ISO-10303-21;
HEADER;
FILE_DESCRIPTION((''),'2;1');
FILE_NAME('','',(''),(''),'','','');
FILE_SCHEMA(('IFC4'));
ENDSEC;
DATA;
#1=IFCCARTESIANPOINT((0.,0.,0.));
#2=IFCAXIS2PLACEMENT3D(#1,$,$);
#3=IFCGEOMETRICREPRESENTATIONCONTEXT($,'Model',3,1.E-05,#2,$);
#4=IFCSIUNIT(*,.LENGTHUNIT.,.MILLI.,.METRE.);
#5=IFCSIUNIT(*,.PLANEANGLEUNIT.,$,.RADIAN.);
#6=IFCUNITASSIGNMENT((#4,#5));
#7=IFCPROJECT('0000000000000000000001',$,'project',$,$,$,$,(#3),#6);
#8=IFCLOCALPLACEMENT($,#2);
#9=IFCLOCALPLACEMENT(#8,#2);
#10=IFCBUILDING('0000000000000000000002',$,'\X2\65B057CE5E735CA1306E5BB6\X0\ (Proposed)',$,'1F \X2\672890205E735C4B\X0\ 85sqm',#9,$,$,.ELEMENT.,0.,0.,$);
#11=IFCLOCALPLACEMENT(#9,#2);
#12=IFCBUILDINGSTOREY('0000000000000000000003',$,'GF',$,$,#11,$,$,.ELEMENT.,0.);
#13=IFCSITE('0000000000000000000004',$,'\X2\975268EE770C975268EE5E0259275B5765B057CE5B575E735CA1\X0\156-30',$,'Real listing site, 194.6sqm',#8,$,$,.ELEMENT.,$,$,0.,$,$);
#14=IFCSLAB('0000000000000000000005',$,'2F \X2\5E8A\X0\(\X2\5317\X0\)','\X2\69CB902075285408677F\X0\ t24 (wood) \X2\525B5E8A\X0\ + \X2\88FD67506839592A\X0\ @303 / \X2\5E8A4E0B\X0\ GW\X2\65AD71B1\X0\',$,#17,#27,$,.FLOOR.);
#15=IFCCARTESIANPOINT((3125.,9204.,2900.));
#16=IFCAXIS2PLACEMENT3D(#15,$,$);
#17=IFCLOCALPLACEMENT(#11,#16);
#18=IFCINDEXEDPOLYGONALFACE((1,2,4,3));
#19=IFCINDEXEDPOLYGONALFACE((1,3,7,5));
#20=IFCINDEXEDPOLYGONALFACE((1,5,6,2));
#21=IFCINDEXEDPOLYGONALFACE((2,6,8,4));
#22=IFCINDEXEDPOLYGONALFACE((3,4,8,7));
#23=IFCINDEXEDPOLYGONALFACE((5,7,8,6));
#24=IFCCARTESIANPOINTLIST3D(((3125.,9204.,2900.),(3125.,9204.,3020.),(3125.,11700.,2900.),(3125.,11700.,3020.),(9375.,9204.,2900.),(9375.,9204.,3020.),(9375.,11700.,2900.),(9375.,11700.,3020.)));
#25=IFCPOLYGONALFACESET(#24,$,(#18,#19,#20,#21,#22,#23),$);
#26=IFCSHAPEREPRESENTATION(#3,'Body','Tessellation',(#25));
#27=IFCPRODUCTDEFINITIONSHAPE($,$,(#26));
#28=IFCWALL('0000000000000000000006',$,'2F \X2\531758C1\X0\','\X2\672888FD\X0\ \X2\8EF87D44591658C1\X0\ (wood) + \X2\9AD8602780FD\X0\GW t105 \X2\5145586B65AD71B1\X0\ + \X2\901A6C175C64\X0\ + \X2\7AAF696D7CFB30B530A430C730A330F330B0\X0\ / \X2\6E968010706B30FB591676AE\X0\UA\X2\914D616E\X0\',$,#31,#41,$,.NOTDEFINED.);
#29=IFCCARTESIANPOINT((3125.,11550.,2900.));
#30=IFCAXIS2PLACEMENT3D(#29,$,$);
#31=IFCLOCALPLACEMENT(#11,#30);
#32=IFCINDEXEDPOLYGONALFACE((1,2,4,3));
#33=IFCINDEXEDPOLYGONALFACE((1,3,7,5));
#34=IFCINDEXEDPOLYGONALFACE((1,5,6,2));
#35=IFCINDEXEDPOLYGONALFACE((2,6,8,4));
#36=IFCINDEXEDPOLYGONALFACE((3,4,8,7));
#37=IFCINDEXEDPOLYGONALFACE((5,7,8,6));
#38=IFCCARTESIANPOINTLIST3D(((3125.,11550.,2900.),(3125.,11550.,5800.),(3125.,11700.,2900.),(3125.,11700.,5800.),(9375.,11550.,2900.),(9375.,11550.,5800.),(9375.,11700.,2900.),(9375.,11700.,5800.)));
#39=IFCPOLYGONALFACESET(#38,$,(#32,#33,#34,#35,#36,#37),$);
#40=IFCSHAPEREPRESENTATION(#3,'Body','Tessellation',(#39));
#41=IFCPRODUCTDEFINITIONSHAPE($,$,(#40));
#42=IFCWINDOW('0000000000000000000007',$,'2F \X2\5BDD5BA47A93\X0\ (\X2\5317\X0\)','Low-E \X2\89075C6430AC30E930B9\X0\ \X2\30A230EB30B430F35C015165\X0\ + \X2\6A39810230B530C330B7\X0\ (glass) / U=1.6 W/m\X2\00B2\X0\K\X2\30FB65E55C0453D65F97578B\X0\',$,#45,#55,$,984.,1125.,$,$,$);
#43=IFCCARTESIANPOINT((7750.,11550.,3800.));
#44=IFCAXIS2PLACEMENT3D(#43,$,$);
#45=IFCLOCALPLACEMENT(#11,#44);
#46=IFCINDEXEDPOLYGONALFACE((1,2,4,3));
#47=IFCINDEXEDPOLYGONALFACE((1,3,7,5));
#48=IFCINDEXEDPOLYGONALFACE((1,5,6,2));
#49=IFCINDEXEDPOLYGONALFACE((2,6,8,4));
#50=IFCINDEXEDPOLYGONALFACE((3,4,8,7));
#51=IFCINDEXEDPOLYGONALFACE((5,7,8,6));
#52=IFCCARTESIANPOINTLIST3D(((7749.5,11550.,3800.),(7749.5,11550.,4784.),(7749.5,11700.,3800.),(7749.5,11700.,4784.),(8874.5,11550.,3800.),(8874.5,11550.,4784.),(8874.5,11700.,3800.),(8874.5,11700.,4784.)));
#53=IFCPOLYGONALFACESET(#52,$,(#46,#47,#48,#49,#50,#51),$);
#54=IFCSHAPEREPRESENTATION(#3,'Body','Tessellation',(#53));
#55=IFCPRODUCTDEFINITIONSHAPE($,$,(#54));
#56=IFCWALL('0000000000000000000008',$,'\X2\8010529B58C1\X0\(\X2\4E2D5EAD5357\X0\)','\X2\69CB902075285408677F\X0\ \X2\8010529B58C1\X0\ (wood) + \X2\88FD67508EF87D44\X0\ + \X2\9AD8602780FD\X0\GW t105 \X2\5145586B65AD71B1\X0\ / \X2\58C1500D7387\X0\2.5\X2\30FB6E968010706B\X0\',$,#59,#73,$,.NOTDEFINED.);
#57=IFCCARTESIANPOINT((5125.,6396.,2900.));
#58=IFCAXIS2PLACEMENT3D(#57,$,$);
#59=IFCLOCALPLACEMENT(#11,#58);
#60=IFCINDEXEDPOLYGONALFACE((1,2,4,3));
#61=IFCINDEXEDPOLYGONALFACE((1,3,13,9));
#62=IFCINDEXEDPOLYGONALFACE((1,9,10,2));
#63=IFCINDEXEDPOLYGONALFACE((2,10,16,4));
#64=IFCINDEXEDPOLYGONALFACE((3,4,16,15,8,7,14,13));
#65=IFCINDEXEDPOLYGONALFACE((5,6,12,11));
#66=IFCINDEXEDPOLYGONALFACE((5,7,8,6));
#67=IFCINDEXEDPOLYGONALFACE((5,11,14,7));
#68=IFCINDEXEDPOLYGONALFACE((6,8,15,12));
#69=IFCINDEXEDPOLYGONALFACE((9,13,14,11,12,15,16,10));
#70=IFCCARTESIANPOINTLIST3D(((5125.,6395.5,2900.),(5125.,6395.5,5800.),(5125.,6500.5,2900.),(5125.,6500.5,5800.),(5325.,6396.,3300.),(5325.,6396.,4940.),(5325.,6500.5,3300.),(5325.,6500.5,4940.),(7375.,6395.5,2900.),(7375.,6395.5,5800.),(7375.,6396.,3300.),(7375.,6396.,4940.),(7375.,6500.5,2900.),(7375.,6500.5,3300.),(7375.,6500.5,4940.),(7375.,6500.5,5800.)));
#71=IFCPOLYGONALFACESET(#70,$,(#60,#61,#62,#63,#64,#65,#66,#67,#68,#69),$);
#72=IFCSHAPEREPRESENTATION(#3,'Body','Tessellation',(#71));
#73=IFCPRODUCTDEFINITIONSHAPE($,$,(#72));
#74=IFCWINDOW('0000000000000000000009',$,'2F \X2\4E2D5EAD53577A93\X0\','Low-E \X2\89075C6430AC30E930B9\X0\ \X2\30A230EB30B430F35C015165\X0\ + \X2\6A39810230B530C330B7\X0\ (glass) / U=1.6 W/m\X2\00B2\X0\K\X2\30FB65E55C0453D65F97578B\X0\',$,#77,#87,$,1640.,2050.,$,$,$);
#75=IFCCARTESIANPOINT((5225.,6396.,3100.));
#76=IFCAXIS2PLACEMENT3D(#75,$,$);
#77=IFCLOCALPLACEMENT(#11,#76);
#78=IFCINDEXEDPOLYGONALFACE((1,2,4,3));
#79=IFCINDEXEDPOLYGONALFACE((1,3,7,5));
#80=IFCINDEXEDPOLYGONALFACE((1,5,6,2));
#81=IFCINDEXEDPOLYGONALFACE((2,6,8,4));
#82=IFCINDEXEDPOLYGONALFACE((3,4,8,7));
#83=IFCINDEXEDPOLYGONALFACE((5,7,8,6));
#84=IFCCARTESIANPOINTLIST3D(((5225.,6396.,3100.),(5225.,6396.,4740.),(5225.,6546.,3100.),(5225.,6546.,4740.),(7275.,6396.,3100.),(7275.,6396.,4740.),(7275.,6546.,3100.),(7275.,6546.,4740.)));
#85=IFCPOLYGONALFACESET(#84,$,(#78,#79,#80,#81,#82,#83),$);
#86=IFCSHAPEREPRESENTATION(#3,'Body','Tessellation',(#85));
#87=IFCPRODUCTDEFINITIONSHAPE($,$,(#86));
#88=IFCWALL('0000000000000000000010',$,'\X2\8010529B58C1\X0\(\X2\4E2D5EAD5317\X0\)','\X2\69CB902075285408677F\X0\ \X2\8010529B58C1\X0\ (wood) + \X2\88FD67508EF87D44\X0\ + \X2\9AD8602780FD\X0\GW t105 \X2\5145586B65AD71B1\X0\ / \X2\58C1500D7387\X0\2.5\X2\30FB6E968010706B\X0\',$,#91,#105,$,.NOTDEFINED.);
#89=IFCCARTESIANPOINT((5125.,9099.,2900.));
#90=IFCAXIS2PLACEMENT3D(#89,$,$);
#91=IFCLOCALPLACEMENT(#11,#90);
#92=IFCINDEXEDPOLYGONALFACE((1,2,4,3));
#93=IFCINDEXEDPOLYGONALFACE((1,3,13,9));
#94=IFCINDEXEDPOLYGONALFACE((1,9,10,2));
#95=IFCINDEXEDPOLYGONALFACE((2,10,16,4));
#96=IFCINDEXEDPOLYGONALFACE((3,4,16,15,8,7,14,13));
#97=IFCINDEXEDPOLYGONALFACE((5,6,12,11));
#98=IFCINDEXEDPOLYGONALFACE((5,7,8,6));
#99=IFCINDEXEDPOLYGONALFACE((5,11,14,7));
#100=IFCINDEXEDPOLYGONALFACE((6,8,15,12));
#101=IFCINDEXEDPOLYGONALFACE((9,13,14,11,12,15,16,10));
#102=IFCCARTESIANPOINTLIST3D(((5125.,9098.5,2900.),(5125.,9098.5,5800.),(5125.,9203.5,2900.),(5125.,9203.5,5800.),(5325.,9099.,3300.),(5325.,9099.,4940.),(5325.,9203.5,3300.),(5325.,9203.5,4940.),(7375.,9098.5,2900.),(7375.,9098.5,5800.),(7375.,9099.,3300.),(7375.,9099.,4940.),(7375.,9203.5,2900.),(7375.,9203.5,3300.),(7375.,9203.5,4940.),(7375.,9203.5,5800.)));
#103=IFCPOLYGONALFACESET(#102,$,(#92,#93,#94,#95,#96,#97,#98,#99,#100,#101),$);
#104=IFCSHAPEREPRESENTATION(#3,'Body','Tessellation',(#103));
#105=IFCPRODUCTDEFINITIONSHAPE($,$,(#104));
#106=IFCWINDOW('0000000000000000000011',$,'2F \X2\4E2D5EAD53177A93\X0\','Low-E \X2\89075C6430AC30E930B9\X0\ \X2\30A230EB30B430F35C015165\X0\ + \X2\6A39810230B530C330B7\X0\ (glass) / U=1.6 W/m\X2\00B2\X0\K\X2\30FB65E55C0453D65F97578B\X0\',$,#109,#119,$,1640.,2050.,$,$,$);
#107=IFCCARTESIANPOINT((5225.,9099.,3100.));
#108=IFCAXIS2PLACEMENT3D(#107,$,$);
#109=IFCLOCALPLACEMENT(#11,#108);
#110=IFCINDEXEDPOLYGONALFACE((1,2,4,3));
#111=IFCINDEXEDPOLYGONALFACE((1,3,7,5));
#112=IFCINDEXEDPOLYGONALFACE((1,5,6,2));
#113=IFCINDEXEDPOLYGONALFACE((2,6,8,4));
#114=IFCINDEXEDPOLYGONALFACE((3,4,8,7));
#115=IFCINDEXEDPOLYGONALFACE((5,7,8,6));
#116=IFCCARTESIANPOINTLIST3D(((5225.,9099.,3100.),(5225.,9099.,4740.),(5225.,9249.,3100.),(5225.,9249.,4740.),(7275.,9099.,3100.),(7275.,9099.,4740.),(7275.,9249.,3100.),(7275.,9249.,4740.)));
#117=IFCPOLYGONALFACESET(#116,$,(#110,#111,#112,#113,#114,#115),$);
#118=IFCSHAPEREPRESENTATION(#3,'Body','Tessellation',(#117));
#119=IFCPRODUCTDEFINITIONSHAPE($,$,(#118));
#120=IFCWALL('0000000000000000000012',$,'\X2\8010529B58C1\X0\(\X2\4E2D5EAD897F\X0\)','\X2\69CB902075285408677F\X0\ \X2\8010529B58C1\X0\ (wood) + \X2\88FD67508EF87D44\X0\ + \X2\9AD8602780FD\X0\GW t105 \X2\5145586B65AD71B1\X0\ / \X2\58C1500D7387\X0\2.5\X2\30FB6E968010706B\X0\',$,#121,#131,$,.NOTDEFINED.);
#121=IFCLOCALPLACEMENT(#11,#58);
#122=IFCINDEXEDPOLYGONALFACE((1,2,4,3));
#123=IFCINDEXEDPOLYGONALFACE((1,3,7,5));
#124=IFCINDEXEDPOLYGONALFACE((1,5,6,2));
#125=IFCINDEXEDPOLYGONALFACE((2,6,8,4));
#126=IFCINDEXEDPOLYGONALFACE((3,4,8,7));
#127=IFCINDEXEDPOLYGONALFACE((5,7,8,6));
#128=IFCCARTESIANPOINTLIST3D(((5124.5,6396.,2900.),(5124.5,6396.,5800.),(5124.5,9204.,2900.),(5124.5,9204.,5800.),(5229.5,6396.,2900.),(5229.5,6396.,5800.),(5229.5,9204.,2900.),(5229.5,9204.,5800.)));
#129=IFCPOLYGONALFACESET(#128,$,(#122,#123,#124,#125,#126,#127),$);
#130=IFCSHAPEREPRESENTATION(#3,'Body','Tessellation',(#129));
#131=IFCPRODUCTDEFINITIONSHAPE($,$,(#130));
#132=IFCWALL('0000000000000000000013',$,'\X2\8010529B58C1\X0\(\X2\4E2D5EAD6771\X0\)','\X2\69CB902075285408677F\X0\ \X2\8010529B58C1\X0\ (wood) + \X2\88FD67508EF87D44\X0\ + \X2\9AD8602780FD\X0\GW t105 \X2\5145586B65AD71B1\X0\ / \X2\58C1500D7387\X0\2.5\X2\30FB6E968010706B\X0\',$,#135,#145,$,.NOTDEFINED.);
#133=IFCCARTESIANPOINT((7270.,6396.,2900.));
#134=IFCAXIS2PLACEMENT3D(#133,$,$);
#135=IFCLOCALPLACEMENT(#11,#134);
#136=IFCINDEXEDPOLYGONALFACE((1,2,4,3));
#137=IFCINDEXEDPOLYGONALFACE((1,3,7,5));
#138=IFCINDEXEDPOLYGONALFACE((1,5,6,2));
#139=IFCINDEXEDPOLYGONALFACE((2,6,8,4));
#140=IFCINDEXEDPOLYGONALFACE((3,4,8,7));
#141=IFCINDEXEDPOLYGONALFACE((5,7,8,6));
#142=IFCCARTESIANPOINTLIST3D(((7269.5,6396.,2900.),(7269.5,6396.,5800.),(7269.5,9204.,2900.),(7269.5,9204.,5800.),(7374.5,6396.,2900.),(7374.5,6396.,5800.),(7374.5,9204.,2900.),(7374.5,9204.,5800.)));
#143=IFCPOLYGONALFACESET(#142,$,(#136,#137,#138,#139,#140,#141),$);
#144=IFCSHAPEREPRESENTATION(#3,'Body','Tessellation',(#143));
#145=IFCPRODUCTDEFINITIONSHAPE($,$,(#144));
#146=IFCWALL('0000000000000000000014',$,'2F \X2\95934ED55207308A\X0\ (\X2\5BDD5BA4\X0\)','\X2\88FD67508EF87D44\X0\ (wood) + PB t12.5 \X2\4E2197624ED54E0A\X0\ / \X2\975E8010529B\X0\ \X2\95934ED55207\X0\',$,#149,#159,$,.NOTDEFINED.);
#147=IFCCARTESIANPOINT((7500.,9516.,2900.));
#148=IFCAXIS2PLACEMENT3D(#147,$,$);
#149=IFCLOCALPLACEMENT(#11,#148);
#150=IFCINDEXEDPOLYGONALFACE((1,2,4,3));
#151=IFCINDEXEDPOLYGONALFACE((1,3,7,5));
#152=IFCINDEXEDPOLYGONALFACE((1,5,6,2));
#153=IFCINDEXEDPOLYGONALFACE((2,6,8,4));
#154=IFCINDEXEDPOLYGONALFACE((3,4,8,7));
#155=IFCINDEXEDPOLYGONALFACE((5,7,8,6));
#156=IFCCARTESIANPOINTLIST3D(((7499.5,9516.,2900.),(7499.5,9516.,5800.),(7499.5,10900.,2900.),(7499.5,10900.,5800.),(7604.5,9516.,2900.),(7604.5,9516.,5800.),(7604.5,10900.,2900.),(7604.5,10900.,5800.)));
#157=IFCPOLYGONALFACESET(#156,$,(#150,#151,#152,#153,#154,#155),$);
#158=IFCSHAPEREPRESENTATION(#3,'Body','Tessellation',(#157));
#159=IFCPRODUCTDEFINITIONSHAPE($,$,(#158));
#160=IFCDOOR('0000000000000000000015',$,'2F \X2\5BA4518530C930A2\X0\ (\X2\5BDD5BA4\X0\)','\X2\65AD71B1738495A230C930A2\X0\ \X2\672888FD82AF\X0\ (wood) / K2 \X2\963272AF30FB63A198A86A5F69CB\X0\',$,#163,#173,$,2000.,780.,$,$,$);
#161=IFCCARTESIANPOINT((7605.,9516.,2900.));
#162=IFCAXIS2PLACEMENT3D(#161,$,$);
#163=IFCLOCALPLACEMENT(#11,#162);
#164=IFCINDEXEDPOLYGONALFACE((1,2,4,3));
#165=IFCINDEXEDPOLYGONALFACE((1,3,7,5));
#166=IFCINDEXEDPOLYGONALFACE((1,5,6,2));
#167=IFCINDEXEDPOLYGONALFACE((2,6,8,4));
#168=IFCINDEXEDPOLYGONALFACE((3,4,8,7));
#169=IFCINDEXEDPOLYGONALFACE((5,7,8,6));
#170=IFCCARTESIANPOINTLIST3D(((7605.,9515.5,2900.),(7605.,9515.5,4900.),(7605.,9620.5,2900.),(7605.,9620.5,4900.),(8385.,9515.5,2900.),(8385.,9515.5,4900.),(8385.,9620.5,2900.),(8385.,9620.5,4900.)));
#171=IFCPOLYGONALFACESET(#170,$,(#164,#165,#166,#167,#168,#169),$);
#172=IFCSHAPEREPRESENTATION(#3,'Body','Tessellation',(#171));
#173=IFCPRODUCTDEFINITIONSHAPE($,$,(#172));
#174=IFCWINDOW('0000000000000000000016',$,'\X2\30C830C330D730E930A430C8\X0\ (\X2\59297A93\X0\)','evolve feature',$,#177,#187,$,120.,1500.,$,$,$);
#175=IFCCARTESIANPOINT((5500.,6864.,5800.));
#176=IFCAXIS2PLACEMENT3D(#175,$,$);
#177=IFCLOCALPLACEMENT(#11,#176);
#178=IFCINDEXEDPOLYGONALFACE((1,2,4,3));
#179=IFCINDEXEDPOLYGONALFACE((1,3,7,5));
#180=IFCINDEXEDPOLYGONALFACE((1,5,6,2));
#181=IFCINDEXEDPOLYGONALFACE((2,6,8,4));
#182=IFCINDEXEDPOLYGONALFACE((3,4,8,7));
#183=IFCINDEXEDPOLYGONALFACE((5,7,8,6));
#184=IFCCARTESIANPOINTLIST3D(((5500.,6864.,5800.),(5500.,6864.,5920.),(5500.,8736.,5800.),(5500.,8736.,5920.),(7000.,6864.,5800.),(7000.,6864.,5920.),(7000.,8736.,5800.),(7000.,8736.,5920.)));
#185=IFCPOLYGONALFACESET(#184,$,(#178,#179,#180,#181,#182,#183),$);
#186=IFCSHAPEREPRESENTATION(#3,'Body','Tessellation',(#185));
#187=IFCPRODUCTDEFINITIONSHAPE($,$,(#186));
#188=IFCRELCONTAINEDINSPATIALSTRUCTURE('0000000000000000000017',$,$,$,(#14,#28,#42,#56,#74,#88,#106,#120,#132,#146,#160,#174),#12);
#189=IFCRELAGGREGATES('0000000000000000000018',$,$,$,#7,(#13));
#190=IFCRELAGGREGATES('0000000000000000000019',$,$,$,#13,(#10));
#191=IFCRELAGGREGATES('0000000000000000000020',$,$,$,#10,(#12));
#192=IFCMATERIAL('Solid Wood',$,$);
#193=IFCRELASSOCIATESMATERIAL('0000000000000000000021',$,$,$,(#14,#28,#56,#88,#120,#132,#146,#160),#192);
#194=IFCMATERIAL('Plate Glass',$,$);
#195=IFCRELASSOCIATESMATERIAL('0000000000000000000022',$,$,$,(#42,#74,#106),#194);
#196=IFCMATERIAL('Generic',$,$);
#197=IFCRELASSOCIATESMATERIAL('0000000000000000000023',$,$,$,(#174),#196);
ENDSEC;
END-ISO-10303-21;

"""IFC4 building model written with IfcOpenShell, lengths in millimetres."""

from ifc_helpers import new_model, si_unit, frame, frame_2d, origin, place, context, project, spatial, rectangle, extrude, material, element, fill, save


model = new_model("IFC4")

# Units and contexts
model_context = context("Model", 3, precision=1e-05, world=origin())
ifc_project = project(units=[si_unit("LENGTHUNIT", "METRE", prefix="MILLI"), si_unit("PLANEANGLEUNIT", "RADIAN")], contexts=[model_context])

# Site, building, storey
site_placement = place(None, origin())
site = spatial("IfcSite", under=ifc_project, at=site_placement, Name="青森県青森市大字新城字平岡156-30", ObjectType="Real listing site, 194.6sqm", CompositionType="ELEMENT", RefElevation=0.0)
building_placement = place(site_placement, origin())
building = spatial("IfcBuilding", under=site, at=building_placement, Name="新城平岡の家 (Proposed)", ObjectType="1F 木造平屋 85sqm", CompositionType="ELEMENT", ElevationOfRefHeight=0.0, ElevationOfTerrain=0.0)
storey_placement = place(building_placement, origin())
storey = spatial("IfcBuildingStorey", under=building, at=storey_placement, Name="GF", CompositionType="ELEMENT", Elevation=0.0)

# Slab
ifc_material_1 = material(Name="Solid Wood")
slab_placement = place(storey_placement, frame((3125.0, 9204.0, 2900.0)))
element("IfcSlab", 1, at=slab_placement, inside=storey, material=ifc_material_1, Name="2F 床(北)", Description="構造用合板 t24 (wood) 剛床 + 製材根太 @303 / 床下 GW断熱", PredefinedType="FLOOR", context=model_context, shape_type="SweptSolid", body=[
    extrude(rectangle(XDim=6250.0, YDim=2496.0, at=frame_2d((3125.0, 1248.0))), frame((3125.0, 9204.0, 2900.0)), (0.0, 0.0, 1.0), 120.0),
])

# Walls, openings, windows
wall_1_placement = place(storey_placement, frame((3125.0, 11550.0, 2900.0)))
wall_1 = element("IfcWall", 2, at=wall_1_placement, inside=storey, material=ifc_material_1, Name="2F 北壁", Description="木製 軸組外壁 (wood) + 高性能GW t105 充填断熱 + 通気層 + 窯業系サイディング / 準耐火・外皮UA配慮", PredefinedType="NOTDEFINED", context=model_context, shape_type="SweptSolid", body=[
    extrude(rectangle(XDim=6250.0, YDim=150.0, at=frame_2d((3125.0, 75.0))), frame((3125.0, 11550.0, 2900.0)), (0.0, 0.0, 1.0), 2900.0),
])
opening_1_placement = place(storey_placement, frame((7750.0, 11550.0, 3800.0)))
opening_1 = element("IfcOpeningElement", 3, at=opening_1_placement, cuts=wall_1, PredefinedType="NOTDEFINED", context=model_context, shape_type="SweptSolid", body=[
    extrude(rectangle(XDim=1125.0, YDim=150.0, at=frame_2d((562.0, 75.0))), frame((7750.0, 11550.0, 3800.0)), (0.0, 0.0, 1.0), 984.0),
])
ifc_material_2 = material(Name="Plate Glass")
window_1_placement = place(storey_placement, frame((7750.0, 11550.0, 3800.0)))
window_1 = element("IfcWindow", 4, at=window_1_placement, inside=storey, material=ifc_material_2, Name="2F 寝室窓 (北)", Description="Low-E 複層ガラス アルゴン封入 + 樹脂サッシ (glass) / U=1.6 W/m²K・日射取得型", OverallHeight=984.0, OverallWidth=1125.0, context=model_context, shape_type="SweptSolid", body=[
    extrude(rectangle(XDim=1125.0, YDim=150.0, at=frame_2d((562.0, 75.0))), frame((7750.0, 11550.0, 3800.0)), (0.0, 0.0, 1.0), 984.0),
])
fill(opening_1, window_1)
wall_2_placement = place(storey_placement, frame((5125.0, 6396.0, 2900.0)))
wall_2 = element("IfcWall", 5, at=wall_2_placement, inside=storey, material=ifc_material_1, Name="耐力壁(中庭南)", Description="構造用合板 耐力壁 (wood) + 製材軸組 + 高性能GW t105 充填断熱 / 壁倍率2.5・準耐火", PredefinedType="NOTDEFINED", context=model_context, shape_type="SweptSolid", body=[
    extrude(rectangle(XDim=2250.0, YDim=105.0, at=frame_2d((1125.0, 52.0))), frame((5125.0, 6396.0, 2900.0)), (0.0, 0.0, 1.0), 2900.0),
])
opening_2_placement = place(storey_placement, frame((5225.0, 6396.0, 3100.0)))
opening_2 = element("IfcOpeningElement", 6, at=opening_2_placement, cuts=wall_2, PredefinedType="NOTDEFINED", context=model_context, shape_type="SweptSolid", body=[
    extrude(rectangle(XDim=2050.0, YDim=150.0, at=frame_2d((1025.0, 75.0))), frame((5225.0, 6396.0, 3100.0)), (0.0, 0.0, 1.0), 1640.0),
])
window_2_placement = place(storey_placement, frame((5225.0, 6396.0, 3100.0)))
window_2 = element("IfcWindow", 7, at=window_2_placement, inside=storey, material=ifc_material_2, Name="2F 中庭南窓", Description="Low-E 複層ガラス アルゴン封入 + 樹脂サッシ (glass) / U=1.6 W/m²K・日射取得型", OverallHeight=1640.0, OverallWidth=2050.0, context=model_context, shape_type="SweptSolid", body=[
    extrude(rectangle(XDim=2050.0, YDim=150.0, at=frame_2d((1025.0, 75.0))), frame((5225.0, 6396.0, 3100.0)), (0.0, 0.0, 1.0), 1640.0),
])
fill(opening_2, window_2)
wall_3_placement = place(storey_placement, frame((5125.0, 9099.0, 2900.0)))
wall_3 = element("IfcWall", 8, at=wall_3_placement, inside=storey, material=ifc_material_1, Name="耐力壁(中庭北)", Description="構造用合板 耐力壁 (wood) + 製材軸組 + 高性能GW t105 充填断熱 / 壁倍率2.5・準耐火", PredefinedType="NOTDEFINED", context=model_context, shape_type="SweptSolid", body=[
    extrude(rectangle(XDim=2250.0, YDim=105.0, at=frame_2d((1125.0, 52.0))), frame((5125.0, 9099.0, 2900.0)), (0.0, 0.0, 1.0), 2900.0),
])
opening_3_placement = place(storey_placement, frame((5225.0, 9099.0, 3100.0)))
opening_3 = element("IfcOpeningElement", 9, at=opening_3_placement, cuts=wall_3, PredefinedType="NOTDEFINED", context=model_context, shape_type="SweptSolid", body=[
    extrude(rectangle(XDim=2050.0, YDim=150.0, at=frame_2d((1025.0, 75.0))), frame((5225.0, 9099.0, 3100.0)), (0.0, 0.0, 1.0), 1640.0),
])
window_3_placement = place(storey_placement, frame((5225.0, 9099.0, 3100.0)))
window_3 = element("IfcWindow", 10, at=window_3_placement, inside=storey, material=ifc_material_2, Name="2F 中庭北窓", Description="Low-E 複層ガラス アルゴン封入 + 樹脂サッシ (glass) / U=1.6 W/m²K・日射取得型", OverallHeight=1640.0, OverallWidth=2050.0, context=model_context, shape_type="SweptSolid", body=[
    extrude(rectangle(XDim=2050.0, YDim=150.0, at=frame_2d((1025.0, 75.0))), frame((5225.0, 9099.0, 3100.0)), (0.0, 0.0, 1.0), 1640.0),
])
fill(opening_3, window_3)

# Walls
wall_4_placement = place(storey_placement, frame((5125.0, 6396.0, 2900.0)))
element("IfcWall", 11, at=wall_4_placement, inside=storey, material=ifc_material_1, Name="耐力壁(中庭西)", Description="構造用合板 耐力壁 (wood) + 製材軸組 + 高性能GW t105 充填断熱 / 壁倍率2.5・準耐火", PredefinedType="NOTDEFINED", context=model_context, shape_type="SweptSolid", body=[
    extrude(rectangle(XDim=105.0, YDim=2808.0, at=frame_2d((52.0, 1404.0))), frame((5125.0, 6396.0, 2900.0)), (0.0, 0.0, 1.0), 2900.0),
])
wall_5_placement = place(storey_placement, frame((7270.0, 6396.0, 2900.0)))
element("IfcWall", 12, at=wall_5_placement, inside=storey, material=ifc_material_1, Name="耐力壁(中庭東)", Description="構造用合板 耐力壁 (wood) + 製材軸組 + 高性能GW t105 充填断熱 / 壁倍率2.5・準耐火", PredefinedType="NOTDEFINED", context=model_context, shape_type="SweptSolid", body=[
    extrude(rectangle(XDim=105.0, YDim=2808.0, at=frame_2d((52.0, 1404.0))), frame((7270.0, 6396.0, 2900.0)), (0.0, 0.0, 1.0), 2900.0),
])
wall_6_placement = place(storey_placement, frame((7500.0, 9516.0, 2900.0)))
element("IfcWall", 13, at=wall_6_placement, inside=storey, material=ifc_material_1, Name="2F 間仕切り (寝室)", Description="製材軸組 (wood) + PB t12.5 両面仕上 / 非耐力 間仕切", PredefinedType="NOTDEFINED", context=model_context, shape_type="SweptSolid", body=[
    extrude(rectangle(XDim=105.0, YDim=1384.0, at=frame_2d((52.0, 692.0))), frame((7500.0, 9516.0, 2900.0)), (0.0, 0.0, 1.0), 2900.0),
])

# Door
door_placement = place(storey_placement, frame((7605.0, 9516.0, 2900.0)))
element("IfcDoor", 14, at=door_placement, inside=storey, material=ifc_material_1, Name="2F 室内ドア (寝室)", Description="断熱玄関ドア 木製芯 (wood) / K2 防犯・採風機構", OverallHeight=2000.0, OverallWidth=780.0, context=model_context, shape_type="SweptSolid", body=[
    extrude(rectangle(XDim=780.0, YDim=105.0, at=frame_2d((390.0, 52.0))), frame((7605.0, 9516.0, 2900.0)), (0.0, 0.0, 1.0), 2000.0),
])

# Window
ifc_material_3 = material(Name="Generic")
window_4_placement = place(storey_placement, frame((5500.0, 6864.0, 5800.0)))
element("IfcWindow", 15, at=window_4_placement, inside=storey, material=ifc_material_3, Name="トップライト (天窓)", Description="evolve feature", OverallHeight=120.0, OverallWidth=1500.0, context=model_context, shape_type="SweptSolid", body=[
    extrude(rectangle(XDim=1500.0, YDim=1872.0, at=frame_2d((750.0, 936.0))), frame((5500.0, 6864.0, 5800.0)), (0.0, 0.0, 1.0), 120.0),
])

save(model, "model.ifc")
